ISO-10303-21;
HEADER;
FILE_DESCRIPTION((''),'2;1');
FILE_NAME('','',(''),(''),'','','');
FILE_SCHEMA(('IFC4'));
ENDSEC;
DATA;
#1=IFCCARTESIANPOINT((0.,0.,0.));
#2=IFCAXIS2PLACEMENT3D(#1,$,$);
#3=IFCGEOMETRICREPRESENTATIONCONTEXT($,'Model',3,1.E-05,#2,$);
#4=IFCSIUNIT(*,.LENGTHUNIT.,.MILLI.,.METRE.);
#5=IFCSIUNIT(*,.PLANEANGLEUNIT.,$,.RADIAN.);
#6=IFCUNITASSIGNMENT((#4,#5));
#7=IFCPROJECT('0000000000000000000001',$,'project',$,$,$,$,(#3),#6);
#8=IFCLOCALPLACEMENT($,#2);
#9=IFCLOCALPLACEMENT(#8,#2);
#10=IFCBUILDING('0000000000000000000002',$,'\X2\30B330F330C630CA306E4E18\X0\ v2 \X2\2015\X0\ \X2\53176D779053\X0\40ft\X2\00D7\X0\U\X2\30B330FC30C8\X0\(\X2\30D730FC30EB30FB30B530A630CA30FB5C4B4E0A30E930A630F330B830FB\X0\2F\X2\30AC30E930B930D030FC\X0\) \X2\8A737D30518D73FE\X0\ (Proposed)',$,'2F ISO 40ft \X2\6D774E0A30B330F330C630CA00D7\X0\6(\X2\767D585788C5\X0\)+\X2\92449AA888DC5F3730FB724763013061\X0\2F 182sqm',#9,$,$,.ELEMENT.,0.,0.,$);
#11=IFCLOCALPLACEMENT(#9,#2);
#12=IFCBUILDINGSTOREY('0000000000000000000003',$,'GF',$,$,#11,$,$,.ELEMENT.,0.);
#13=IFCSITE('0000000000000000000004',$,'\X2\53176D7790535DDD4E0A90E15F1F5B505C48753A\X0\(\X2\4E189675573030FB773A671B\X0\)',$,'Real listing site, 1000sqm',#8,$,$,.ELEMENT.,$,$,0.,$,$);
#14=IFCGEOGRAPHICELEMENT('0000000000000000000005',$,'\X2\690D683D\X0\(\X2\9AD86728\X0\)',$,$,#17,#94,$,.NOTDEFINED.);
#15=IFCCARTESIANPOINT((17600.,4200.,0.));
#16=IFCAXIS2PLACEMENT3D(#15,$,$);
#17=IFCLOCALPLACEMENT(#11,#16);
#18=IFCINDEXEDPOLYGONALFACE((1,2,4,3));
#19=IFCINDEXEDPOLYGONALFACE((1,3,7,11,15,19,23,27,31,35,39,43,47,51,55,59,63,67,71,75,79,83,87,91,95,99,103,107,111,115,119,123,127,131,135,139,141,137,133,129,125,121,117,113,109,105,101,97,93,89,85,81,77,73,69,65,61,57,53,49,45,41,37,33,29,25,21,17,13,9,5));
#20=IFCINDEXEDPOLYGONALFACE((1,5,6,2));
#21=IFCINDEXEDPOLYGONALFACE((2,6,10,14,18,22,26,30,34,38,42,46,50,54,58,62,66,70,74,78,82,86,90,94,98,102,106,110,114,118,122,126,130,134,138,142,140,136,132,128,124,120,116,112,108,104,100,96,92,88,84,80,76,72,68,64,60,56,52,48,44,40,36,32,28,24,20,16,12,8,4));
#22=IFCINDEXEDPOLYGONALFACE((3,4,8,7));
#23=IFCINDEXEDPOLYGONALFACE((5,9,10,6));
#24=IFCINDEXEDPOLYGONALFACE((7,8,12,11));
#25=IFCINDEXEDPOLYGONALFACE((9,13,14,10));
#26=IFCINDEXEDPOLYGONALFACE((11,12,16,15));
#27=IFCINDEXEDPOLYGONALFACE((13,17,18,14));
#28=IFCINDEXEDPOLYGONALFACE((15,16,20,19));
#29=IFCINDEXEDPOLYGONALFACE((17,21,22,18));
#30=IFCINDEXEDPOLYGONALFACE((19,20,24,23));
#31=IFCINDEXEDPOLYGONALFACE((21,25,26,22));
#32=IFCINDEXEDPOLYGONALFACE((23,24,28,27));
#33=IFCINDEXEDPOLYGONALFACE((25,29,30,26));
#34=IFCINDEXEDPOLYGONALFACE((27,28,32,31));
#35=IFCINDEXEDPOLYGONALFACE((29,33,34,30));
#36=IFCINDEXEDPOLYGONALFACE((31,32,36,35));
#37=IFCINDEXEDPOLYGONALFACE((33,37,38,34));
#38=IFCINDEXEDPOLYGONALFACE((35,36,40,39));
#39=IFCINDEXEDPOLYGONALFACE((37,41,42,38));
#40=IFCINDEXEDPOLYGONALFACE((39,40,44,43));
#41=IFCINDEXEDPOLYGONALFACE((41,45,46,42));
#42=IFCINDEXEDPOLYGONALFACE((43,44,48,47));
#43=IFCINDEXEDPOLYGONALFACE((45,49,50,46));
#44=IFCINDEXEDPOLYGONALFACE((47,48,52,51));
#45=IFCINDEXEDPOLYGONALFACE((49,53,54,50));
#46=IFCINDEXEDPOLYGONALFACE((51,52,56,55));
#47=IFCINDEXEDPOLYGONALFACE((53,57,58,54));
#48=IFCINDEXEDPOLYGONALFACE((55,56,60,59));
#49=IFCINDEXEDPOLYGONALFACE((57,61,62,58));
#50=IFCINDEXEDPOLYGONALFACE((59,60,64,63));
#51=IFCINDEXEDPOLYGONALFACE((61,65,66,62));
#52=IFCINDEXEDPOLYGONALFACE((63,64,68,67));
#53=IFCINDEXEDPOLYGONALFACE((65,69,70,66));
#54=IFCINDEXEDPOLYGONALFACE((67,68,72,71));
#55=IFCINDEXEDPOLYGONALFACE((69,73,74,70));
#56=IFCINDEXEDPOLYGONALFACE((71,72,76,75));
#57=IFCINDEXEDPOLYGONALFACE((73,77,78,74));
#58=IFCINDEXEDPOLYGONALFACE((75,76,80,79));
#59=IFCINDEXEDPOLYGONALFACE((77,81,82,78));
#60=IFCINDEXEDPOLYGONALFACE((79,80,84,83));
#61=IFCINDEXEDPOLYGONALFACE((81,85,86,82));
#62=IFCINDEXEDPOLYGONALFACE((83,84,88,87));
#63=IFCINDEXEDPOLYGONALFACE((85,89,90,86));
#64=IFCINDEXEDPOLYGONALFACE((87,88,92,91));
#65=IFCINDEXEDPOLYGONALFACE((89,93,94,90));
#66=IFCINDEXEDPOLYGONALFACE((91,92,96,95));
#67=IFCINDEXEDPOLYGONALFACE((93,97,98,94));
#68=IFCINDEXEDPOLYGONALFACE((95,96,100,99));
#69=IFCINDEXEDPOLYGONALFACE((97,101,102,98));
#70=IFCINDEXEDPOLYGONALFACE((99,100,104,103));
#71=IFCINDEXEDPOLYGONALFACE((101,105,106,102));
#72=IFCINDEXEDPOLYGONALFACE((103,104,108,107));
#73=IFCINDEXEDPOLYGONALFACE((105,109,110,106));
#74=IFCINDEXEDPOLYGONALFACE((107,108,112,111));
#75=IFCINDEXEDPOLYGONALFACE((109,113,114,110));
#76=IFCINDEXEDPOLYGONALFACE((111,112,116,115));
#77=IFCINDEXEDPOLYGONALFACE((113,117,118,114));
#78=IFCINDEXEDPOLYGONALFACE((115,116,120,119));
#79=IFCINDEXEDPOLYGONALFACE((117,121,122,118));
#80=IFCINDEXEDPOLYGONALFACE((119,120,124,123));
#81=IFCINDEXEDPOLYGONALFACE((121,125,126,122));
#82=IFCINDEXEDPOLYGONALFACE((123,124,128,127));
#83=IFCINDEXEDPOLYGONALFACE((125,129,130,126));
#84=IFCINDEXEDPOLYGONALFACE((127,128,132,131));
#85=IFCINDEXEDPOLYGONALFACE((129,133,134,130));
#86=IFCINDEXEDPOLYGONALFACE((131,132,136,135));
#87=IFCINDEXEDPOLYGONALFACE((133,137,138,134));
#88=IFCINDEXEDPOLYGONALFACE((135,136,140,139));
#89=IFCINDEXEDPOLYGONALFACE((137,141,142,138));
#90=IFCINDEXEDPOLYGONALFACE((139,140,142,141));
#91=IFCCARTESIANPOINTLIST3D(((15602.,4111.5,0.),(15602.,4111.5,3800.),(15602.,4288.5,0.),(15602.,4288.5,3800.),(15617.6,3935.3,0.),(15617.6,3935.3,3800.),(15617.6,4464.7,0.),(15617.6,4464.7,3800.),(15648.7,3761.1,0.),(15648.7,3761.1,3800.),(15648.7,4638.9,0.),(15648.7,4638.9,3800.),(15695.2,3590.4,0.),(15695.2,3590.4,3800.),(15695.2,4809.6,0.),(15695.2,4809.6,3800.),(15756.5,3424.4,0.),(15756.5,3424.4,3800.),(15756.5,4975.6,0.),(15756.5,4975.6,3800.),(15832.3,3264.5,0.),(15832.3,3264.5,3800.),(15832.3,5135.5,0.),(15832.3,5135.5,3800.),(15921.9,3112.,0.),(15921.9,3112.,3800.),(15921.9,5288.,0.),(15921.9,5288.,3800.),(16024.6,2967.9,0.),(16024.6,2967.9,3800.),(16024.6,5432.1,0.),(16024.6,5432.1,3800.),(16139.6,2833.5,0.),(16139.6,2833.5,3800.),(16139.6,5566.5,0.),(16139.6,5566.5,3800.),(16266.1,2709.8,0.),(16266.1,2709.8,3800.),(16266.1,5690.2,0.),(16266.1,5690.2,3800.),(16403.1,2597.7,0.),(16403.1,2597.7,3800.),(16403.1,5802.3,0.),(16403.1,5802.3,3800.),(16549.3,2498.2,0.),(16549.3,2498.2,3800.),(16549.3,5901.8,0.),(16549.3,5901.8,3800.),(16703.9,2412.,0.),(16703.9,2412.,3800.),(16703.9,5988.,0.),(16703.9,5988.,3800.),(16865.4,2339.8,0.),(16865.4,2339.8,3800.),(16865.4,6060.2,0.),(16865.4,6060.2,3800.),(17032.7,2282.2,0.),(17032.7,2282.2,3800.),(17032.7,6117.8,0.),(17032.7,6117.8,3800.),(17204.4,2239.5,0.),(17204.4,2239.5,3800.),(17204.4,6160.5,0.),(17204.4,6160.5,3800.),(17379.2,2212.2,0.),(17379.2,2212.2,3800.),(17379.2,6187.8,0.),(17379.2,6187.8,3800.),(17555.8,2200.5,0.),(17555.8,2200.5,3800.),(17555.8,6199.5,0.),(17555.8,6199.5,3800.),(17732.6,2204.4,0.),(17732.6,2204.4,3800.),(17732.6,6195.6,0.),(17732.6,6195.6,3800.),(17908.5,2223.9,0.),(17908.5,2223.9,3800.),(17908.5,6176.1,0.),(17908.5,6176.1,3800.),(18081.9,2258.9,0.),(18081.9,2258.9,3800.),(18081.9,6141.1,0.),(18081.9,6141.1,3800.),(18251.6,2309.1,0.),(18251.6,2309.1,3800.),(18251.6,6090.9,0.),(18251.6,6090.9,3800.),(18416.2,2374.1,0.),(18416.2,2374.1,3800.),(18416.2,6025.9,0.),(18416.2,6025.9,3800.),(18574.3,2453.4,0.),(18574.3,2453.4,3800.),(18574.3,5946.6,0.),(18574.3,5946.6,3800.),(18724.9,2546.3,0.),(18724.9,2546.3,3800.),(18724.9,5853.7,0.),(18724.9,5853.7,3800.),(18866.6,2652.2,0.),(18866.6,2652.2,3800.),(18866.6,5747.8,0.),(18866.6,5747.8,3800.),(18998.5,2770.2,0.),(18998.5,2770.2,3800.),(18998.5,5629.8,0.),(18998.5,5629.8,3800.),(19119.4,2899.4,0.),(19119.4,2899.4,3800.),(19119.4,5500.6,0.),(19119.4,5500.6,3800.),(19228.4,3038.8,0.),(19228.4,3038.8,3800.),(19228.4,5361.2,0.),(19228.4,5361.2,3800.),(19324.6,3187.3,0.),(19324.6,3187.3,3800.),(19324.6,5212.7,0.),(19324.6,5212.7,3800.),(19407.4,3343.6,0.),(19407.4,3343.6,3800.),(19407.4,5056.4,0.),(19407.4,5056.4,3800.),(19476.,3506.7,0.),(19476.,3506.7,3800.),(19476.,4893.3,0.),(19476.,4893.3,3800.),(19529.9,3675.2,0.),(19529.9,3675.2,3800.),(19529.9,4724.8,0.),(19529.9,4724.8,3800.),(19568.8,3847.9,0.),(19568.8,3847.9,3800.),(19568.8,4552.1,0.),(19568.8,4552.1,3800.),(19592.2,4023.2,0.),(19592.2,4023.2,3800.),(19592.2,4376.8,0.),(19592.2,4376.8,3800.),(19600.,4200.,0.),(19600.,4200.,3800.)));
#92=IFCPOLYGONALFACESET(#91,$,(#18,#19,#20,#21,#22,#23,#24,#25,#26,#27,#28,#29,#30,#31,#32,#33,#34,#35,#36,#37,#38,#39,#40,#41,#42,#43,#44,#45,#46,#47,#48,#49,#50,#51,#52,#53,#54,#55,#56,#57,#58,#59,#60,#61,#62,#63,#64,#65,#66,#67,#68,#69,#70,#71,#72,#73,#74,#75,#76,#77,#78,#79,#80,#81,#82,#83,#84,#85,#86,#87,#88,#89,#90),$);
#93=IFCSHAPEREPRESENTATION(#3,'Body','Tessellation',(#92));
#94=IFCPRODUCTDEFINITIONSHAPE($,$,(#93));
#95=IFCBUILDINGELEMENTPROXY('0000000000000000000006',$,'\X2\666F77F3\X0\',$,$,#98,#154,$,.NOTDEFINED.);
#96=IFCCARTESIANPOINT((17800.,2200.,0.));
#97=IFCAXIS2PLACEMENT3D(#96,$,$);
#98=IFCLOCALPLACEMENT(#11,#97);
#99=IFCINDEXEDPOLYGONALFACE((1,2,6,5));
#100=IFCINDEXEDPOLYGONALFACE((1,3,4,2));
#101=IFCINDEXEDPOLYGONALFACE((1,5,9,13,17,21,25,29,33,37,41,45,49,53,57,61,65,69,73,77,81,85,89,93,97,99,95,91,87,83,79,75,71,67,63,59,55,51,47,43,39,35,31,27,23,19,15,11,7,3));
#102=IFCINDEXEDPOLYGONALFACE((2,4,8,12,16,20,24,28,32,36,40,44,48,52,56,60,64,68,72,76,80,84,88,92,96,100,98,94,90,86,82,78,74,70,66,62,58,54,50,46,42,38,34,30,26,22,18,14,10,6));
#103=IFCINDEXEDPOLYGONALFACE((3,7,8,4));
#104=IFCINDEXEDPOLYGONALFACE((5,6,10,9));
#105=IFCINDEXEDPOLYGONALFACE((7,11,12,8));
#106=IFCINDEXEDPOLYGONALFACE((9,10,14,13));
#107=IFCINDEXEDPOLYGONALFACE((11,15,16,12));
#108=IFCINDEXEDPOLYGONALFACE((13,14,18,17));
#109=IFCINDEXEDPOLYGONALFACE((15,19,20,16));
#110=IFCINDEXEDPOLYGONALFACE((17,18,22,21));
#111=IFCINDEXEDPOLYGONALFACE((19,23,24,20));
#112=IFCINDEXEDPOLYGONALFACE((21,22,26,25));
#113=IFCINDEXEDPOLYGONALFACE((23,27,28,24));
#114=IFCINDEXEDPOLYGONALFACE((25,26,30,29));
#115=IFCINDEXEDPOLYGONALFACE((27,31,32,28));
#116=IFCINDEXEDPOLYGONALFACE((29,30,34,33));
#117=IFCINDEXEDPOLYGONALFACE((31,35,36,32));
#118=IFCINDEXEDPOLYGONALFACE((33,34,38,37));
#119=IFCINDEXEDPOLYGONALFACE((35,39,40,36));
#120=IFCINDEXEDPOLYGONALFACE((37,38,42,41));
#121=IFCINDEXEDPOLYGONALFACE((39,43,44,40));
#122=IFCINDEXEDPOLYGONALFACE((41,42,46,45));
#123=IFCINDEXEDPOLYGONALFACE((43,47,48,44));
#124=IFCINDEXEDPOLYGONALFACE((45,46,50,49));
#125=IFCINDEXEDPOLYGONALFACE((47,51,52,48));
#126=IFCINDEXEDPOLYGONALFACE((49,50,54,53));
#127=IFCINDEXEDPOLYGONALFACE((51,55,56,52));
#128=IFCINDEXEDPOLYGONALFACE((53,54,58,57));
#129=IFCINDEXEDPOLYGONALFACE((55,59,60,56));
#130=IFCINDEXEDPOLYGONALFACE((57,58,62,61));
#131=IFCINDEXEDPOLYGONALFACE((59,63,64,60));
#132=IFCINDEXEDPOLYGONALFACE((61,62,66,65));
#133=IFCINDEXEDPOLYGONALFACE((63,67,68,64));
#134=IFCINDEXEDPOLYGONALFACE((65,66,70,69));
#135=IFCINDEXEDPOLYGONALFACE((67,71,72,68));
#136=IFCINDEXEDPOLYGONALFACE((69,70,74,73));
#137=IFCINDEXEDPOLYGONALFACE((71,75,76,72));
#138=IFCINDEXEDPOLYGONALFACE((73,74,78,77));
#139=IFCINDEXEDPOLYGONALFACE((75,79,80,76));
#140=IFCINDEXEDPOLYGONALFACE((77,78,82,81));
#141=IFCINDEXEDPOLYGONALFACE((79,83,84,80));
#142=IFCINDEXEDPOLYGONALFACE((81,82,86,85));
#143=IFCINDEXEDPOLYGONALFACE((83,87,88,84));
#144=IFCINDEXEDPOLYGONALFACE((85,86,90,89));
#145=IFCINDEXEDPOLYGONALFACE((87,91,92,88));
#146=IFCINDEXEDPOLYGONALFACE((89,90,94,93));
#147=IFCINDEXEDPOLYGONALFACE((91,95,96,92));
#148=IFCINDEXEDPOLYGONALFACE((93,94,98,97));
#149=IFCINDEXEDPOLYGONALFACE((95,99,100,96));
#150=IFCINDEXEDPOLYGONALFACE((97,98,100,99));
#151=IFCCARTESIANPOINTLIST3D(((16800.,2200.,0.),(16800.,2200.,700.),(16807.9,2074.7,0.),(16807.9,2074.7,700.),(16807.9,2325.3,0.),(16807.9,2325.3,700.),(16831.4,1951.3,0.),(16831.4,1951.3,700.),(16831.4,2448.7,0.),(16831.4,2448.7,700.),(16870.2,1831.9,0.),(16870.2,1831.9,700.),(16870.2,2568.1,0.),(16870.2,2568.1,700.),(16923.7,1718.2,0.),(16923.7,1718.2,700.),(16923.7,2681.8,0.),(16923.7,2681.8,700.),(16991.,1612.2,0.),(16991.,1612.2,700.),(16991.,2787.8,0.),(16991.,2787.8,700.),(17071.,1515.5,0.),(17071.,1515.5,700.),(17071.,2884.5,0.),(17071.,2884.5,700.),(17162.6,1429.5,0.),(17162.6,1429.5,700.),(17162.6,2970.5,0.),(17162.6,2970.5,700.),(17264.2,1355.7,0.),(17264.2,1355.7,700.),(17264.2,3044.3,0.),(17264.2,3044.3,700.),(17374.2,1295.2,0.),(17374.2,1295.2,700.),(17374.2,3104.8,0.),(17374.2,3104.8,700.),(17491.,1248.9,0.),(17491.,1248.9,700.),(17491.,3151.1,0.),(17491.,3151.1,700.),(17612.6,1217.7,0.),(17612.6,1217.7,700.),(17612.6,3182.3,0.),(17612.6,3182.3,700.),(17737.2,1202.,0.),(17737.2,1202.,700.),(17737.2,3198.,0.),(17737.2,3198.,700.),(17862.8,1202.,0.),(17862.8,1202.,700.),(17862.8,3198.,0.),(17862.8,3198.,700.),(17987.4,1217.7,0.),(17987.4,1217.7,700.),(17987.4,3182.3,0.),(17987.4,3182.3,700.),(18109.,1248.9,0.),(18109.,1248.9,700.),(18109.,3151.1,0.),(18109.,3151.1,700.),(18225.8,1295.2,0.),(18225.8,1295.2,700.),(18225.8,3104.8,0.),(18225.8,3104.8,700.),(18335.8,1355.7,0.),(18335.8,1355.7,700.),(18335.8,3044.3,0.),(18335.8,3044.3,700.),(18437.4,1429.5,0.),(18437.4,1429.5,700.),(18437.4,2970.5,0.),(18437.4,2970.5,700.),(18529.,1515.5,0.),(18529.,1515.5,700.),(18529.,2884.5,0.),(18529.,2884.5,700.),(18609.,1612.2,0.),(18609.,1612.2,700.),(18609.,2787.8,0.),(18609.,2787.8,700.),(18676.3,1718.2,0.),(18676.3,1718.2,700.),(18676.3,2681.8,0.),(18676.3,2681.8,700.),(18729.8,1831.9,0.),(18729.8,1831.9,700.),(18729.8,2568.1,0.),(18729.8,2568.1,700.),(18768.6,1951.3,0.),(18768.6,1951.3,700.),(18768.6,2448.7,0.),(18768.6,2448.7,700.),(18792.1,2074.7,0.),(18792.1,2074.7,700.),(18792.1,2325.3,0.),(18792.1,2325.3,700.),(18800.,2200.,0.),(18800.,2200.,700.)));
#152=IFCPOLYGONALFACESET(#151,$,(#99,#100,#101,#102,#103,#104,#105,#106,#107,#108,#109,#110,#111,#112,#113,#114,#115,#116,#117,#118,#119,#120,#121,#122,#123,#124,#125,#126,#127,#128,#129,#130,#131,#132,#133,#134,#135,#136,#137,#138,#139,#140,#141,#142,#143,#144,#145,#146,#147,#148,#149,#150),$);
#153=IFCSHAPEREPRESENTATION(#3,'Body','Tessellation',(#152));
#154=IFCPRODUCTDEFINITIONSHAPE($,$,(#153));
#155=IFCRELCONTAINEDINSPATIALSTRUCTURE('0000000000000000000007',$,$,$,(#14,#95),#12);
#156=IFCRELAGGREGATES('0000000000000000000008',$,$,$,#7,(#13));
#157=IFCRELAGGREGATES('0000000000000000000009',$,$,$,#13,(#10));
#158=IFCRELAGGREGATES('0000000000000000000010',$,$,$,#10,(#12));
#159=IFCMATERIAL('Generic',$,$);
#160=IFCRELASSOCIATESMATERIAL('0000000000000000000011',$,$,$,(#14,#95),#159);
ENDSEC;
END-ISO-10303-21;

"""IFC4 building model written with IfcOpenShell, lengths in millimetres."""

from ifc_helpers import new_model, si_unit, frame, origin, origin_2d, place, context, project, spatial, circle, extrude, material, element, save


model = new_model("IFC4")

# Units and contexts
model_context = context("Model", 3, precision=1e-05, world=origin())
ifc_project = project(units=[si_unit("LENGTHUNIT", "METRE", prefix="MILLI"), si_unit("PLANEANGLEUNIT", "RADIAN")], contexts=[model_context])

# Site, building, storey
site_placement = place(None, origin())
site = spatial("IfcSite", under=ifc_project, at=site_placement, Name="北海道川上郡弟子屈町(丘陵地・眺望)", ObjectType="Real listing site, 1000sqm", CompositionType="ELEMENT", RefElevation=0.0)
building_placement = place(site_placement, origin())
building = spatial("IfcBuilding", under=site, at=building_placement, Name="コンテナの丘 v2 ― 北海道40ft×Uコート(プール・サウナ・屋上ラウンジ・2Fガラスバー) 詳細再現 (Proposed)", ObjectType="2F ISO 40ft 海上コンテナ×6(白塗装)+鉄骨補強・片持ち2F 182sqm", CompositionType="ELEMENT", ElevationOfRefHeight=0.0, ElevationOfTerrain=0.0)
storey_placement = place(building_placement, origin())
storey = spatial("IfcBuildingStorey", under=building, at=storey_placement, Name="GF", CompositionType="ELEMENT", Elevation=0.0)

# Shared definitions
ifc_material = material(Name="Generic")

# Geographic element
geographic_element_1_placement = place(storey_placement, frame((17600.0, 4200.0, 0.0)))
element("IfcGeographicElement", 1, at=geographic_element_1_placement, inside=storey, material=ifc_material, Name="植栽(高木)", PredefinedType="NOTDEFINED", context=model_context, shape_type="SweptSolid", body=[
    extrude(circle(Radius=2000.0, at=origin_2d()), frame((17600.0, 4200.0, 0.0)), (0.0, 0.0, 1.0), 3800.0),
])

# Building element proxy
proxy_placement = place(storey_placement, frame((17800.0, 2200.0, 0.0)))
element("IfcBuildingElementProxy", 2, at=proxy_placement, inside=storey, material=ifc_material, Name="景石", PredefinedType="NOTDEFINED", context=model_context, shape_type="SweptSolid", body=[
    extrude(circle(Radius=1000.0, at=origin_2d()), frame((17800.0, 2200.0, 0.0)), (0.0, 0.0, 1.0), 700.0),
])

save(model, "model.ifc")
